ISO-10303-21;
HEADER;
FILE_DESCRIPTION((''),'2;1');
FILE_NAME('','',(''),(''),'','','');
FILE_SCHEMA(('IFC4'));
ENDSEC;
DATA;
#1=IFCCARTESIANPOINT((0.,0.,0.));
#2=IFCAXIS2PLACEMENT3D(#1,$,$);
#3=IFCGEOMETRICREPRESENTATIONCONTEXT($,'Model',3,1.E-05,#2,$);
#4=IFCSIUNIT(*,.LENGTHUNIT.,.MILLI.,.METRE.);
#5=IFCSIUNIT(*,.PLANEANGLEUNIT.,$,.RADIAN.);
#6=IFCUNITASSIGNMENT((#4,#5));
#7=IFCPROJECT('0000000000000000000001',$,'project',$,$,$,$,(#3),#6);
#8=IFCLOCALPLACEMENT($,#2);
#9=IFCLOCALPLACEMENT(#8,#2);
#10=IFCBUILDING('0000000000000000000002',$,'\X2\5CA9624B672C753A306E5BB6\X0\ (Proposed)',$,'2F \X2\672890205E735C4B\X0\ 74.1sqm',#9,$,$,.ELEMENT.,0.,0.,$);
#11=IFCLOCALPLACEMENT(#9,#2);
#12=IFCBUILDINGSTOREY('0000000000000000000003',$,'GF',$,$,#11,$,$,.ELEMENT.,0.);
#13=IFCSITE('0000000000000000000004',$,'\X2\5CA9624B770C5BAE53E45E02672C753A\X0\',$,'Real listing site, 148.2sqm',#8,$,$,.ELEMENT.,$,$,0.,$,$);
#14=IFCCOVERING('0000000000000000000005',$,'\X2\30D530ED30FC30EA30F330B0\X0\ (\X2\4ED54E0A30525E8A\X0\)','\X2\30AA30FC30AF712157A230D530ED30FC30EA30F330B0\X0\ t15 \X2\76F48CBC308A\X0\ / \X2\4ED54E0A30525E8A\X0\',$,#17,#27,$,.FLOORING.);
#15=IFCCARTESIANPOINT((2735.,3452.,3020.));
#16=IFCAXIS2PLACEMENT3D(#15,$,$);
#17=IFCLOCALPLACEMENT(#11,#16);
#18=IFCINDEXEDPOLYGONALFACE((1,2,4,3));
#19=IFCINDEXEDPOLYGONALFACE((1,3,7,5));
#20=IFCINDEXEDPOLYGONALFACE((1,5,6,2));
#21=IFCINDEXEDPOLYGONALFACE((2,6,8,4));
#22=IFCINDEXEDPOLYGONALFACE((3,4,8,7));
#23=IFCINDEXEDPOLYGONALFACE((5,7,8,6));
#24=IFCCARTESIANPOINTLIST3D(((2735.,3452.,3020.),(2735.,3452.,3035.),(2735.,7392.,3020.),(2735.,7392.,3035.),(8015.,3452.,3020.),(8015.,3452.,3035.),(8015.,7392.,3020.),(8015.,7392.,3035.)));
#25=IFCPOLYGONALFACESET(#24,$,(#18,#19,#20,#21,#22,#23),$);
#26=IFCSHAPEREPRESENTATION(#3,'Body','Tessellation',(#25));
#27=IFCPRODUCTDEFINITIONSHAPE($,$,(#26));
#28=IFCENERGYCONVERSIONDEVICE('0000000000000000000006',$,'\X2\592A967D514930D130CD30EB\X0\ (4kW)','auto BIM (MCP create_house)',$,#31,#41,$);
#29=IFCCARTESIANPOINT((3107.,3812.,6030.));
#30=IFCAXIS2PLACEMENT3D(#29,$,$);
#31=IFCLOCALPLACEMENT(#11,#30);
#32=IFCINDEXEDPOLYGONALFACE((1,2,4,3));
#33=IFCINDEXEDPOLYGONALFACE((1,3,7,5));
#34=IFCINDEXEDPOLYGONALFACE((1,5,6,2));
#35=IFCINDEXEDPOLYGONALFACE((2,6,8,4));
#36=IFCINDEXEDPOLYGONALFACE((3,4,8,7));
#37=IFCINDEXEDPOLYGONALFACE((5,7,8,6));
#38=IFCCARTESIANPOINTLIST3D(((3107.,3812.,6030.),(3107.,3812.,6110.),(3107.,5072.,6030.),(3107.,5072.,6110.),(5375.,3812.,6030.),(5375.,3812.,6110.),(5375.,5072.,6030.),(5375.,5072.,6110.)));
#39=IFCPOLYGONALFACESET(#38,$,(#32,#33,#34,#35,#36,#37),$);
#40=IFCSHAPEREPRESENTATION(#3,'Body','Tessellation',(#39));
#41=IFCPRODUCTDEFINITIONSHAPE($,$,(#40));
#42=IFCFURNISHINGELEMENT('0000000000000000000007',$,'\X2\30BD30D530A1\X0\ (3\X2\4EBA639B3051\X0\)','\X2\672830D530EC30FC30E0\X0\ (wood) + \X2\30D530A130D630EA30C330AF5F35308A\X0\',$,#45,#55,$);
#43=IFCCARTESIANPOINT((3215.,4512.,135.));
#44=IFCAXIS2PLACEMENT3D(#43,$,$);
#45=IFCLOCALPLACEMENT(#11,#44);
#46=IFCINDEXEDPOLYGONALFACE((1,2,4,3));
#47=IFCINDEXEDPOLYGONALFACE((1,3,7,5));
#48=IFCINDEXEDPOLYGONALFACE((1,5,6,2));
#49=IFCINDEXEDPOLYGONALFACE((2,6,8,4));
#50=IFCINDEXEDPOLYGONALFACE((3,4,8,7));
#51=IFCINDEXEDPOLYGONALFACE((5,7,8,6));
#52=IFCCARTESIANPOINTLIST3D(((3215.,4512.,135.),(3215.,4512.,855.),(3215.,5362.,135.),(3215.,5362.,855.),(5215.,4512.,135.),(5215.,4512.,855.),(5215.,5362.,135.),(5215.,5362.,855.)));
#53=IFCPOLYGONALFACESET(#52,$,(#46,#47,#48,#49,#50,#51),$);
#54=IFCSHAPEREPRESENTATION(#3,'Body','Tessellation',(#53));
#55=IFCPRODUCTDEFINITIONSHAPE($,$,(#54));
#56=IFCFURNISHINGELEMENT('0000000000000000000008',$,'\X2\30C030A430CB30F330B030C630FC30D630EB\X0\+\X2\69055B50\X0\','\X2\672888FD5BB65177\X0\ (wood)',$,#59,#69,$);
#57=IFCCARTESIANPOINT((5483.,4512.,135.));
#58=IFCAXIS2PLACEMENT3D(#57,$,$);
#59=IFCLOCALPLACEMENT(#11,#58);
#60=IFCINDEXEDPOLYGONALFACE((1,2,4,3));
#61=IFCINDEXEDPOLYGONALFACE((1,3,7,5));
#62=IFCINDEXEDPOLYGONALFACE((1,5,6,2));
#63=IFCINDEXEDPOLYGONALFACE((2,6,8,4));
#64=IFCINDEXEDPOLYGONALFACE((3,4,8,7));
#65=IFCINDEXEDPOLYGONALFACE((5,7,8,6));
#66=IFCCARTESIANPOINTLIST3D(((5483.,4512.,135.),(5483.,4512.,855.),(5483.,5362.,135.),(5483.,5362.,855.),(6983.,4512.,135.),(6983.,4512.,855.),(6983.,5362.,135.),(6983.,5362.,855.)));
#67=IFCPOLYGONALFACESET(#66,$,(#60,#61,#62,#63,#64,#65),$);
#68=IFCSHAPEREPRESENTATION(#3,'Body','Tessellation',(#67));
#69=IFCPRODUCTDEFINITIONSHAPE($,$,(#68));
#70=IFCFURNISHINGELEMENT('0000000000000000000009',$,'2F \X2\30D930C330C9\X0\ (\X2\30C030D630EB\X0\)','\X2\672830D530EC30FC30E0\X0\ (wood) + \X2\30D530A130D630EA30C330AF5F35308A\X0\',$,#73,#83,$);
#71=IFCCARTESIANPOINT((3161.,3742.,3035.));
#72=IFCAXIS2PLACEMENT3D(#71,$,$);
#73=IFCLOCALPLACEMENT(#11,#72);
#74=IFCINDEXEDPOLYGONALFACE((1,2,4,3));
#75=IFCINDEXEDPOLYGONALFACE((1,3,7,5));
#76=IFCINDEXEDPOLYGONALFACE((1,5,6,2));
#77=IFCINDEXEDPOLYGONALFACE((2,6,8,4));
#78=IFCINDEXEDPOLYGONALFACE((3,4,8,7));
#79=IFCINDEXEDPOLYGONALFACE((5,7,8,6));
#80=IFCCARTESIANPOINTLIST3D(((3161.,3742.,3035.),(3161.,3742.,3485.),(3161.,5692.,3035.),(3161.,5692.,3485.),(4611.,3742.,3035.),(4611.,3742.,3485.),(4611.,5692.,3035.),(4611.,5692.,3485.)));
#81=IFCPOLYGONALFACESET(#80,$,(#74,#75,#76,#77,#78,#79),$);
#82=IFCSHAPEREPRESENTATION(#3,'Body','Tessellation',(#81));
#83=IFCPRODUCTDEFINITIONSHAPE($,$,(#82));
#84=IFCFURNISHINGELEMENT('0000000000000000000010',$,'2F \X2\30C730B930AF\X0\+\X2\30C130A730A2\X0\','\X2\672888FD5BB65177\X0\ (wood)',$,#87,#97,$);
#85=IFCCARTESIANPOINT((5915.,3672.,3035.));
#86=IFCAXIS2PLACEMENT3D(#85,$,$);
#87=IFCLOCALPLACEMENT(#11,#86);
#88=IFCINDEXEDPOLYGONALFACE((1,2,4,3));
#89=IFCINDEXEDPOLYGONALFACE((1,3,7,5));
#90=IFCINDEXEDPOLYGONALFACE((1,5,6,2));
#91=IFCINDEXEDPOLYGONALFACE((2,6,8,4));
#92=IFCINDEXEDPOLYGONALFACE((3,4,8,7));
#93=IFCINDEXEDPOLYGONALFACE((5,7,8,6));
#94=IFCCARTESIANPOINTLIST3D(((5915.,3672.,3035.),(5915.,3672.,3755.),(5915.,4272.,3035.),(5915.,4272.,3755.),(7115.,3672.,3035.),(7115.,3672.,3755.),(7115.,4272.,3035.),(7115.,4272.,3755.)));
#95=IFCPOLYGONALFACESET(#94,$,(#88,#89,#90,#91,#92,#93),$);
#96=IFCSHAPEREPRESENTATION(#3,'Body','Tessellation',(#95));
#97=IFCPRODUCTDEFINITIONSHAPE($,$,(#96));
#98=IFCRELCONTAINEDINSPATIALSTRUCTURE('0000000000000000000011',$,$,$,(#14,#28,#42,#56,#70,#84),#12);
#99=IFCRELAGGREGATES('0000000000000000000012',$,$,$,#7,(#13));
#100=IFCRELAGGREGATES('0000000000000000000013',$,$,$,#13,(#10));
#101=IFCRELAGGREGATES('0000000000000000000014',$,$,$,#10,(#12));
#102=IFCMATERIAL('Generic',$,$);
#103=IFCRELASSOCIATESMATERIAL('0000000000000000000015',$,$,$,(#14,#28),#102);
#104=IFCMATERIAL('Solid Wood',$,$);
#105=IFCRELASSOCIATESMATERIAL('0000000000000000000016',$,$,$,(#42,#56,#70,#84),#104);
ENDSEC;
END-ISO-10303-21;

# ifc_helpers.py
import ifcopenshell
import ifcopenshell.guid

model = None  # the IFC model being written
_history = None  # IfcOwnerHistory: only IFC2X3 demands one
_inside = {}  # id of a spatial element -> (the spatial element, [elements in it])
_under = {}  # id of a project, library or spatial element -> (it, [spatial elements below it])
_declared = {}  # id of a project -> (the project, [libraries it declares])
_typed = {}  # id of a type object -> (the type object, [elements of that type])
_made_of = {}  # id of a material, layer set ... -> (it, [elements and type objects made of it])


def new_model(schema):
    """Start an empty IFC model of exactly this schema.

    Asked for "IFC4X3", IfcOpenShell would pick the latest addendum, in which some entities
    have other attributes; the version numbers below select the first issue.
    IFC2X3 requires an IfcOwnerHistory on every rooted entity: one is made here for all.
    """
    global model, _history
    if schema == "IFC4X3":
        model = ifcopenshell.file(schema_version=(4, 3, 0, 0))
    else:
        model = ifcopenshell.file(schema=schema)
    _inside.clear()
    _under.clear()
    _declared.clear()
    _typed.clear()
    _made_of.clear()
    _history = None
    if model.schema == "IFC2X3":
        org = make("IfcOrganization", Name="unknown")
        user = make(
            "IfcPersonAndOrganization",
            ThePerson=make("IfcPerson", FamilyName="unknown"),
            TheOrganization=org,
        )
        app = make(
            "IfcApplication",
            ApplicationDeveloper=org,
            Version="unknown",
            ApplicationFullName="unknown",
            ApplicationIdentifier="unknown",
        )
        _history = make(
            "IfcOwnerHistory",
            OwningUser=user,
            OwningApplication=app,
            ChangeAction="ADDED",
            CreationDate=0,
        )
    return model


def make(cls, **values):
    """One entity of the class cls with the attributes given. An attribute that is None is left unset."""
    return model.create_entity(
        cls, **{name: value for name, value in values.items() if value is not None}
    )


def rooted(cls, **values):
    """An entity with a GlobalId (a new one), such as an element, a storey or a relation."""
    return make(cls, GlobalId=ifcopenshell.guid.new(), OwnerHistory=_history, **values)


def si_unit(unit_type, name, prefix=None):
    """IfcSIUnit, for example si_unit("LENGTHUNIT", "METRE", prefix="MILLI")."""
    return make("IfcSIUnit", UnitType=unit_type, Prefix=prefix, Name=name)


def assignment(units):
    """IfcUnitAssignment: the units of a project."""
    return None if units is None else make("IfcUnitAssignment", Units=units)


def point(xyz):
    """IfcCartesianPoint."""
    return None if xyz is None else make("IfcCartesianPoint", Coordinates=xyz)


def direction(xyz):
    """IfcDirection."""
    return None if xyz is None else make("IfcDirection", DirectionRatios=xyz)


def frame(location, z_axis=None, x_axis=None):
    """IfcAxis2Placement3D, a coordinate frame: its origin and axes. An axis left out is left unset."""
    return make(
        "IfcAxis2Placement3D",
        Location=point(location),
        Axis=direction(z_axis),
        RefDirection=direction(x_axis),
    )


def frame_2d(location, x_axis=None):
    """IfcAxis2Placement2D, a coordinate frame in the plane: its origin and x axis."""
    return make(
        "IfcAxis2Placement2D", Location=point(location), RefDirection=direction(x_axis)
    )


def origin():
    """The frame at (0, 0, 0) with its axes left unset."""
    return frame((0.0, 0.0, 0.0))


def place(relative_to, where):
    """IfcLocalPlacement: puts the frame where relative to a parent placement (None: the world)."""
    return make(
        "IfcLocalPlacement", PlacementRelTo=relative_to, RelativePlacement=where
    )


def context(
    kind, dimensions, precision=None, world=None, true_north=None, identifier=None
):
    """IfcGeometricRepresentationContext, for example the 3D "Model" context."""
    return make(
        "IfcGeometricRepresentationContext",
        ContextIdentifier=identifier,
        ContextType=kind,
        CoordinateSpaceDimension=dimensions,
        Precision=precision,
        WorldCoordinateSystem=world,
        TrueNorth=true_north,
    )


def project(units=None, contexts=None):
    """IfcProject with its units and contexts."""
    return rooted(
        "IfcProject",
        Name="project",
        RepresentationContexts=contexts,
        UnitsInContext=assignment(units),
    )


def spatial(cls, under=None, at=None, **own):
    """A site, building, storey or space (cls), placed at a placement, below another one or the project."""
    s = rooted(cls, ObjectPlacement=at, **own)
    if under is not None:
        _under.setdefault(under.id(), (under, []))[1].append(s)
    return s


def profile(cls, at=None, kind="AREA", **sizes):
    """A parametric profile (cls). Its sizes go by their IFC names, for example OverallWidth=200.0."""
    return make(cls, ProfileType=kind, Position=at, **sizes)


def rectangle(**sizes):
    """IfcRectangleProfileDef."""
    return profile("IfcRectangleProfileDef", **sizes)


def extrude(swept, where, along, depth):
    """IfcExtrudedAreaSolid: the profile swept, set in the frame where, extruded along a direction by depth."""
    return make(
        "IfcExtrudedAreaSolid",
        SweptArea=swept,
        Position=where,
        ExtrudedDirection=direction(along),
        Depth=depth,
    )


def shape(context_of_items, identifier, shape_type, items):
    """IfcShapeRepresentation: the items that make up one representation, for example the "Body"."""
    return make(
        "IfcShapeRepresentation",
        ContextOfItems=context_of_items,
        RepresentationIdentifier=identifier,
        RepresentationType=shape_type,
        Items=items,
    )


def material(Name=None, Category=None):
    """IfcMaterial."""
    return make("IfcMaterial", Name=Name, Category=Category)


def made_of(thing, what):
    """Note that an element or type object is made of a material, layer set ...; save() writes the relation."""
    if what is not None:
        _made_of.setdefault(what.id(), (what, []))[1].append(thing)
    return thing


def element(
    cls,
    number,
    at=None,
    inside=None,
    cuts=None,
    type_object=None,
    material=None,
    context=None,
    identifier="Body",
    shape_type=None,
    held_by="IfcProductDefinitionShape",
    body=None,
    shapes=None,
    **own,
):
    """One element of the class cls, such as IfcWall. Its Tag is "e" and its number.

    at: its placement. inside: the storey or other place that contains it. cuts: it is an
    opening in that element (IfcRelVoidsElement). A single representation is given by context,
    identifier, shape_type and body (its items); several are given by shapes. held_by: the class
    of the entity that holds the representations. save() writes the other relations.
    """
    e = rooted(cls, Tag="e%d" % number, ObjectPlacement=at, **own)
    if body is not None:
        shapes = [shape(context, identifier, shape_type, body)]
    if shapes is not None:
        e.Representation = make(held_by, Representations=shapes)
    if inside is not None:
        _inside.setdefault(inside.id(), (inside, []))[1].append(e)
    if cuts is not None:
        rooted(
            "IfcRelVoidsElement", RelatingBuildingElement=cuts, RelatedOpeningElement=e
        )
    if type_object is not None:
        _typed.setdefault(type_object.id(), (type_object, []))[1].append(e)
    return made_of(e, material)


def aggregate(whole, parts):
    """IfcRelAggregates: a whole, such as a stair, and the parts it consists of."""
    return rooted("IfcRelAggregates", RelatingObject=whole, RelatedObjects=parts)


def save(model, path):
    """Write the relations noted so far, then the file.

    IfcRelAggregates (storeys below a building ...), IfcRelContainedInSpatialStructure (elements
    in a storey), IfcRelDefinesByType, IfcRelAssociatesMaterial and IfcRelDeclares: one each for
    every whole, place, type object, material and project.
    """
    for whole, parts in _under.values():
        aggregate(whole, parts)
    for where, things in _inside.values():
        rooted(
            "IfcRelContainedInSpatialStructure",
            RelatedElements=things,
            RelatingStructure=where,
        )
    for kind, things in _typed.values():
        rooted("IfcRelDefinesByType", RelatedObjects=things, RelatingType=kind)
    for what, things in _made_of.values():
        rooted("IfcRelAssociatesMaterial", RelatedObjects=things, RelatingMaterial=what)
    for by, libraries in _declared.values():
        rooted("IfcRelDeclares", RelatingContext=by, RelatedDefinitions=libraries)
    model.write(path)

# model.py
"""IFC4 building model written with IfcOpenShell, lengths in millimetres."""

from ifc_helpers import new_model, si_unit, frame, frame_2d, origin, place, context, project, spatial, rectangle, extrude, material, element, save


model = new_model("IFC4")

# Units and contexts
model_context = context("Model", 3, precision=1e-05, world=origin())
ifc_project = project(units=[si_unit("LENGTHUNIT", "METRE", prefix="MILLI"), si_unit("PLANEANGLEUNIT", "RADIAN")], contexts=[model_context])

# Site, building, storey
site_placement = place(None, origin())
site = spatial("IfcSite", under=ifc_project, at=site_placement, Name="岩手県宮古市本町", ObjectType="Real listing site, 148.2sqm", CompositionType="ELEMENT", RefElevation=0.0)
building_placement = place(site_placement, origin())
building = spatial("IfcBuilding", under=site, at=building_placement, Name="岩手本町の家 (Proposed)", ObjectType="2F 木造平屋 74.1sqm", CompositionType="ELEMENT", ElevationOfRefHeight=0.0, ElevationOfTerrain=0.0)
storey_placement = place(building_placement, origin())
storey = spatial("IfcBuildingStorey", under=building, at=storey_placement, Name="GF", CompositionType="ELEMENT", Elevation=0.0)

# Shared definitions
ifc_material_1 = material(Name="Solid Wood")

# Covering
ifc_material_2 = material(Name="Generic")
covering_placement = place(storey_placement, frame((2735.0, 3452.0, 3020.0)))
element("IfcCovering", 1, at=covering_placement, inside=storey, material=ifc_material_2, Name="フローリング (仕上げ床)", Description="オーク無垢フローリング t15 直貼り / 仕上げ床", PredefinedType="FLOORING", context=model_context, shape_type="SweptSolid", body=[
    extrude(rectangle(XDim=5280.0, YDim=3940.0, at=frame_2d((2640.0, 1970.0))), frame((2735.0, 3452.0, 3020.0)), (0.0, 0.0, 1.0), 15.0),
])

# Energy conversion device
energy_conversion_device_placement = place(storey_placement, frame((3107.0, 3812.0, 6030.0)))
element("IfcEnergyConversionDevice", 2, at=energy_conversion_device_placement, inside=storey, material=ifc_material_2, Name="太陽光パネル (4kW)", Description="auto BIM (MCP create_house)", context=model_context, shape_type="SweptSolid", body=[
    extrude(rectangle(XDim=2268.0, YDim=1260.0, at=frame_2d((1134.0, 630.0))), frame((3107.0, 3812.0, 6030.0)), (0.0, 0.0, 1.0), 80.0),
])

# Furnishing elements
furnishing_1_placement = place(storey_placement, frame((3215.0, 4512.0, 135.0)))
element("IfcFurnishingElement", 3, at=furnishing_1_placement, inside=storey, material=ifc_material_1, Name="ソファ (3人掛け)", Description="木フレーム (wood) + ファブリック張り", context=model_context, shape_type="SweptSolid", body=[
    extrude(rectangle(XDim=2000.0, YDim=850.0, at=frame_2d((1000.0, 425.0))), frame((3215.0, 4512.0, 135.0)), (0.0, 0.0, 1.0), 720.0),
])
furnishing_2_placement = place(storey_placement, frame((5483.0, 4512.0, 135.0)))
element("IfcFurnishingElement", 4, at=furnishing_2_placement, inside=storey, material=ifc_material_1, Name="ダイニングテーブル+椅子", Description="木製家具 (wood)", context=model_context, shape_type="SweptSolid", body=[
    extrude(rectangle(XDim=1500.0, YDim=850.0, at=frame_2d((750.0, 425.0))), frame((5483.0, 4512.0, 135.0)), (0.0, 0.0, 1.0), 720.0),
])
furnishing_3_placement = place(storey_placement, frame((3161.0, 3742.0, 3035.0)))
element("IfcFurnishingElement", 5, at=furnishing_3_placement, inside=storey, material=ifc_material_1, Name="2F ベッド (ダブル)", Description="木フレーム (wood) + ファブリック張り", context=model_context, shape_type="SweptSolid", body=[
    extrude(rectangle(XDim=1450.0, YDim=1950.0, at=frame_2d((725.0, 975.0))), frame((3161.0, 3742.0, 3035.0)), (0.0, 0.0, 1.0), 450.0),
])
furnishing_4_placement = place(storey_placement, frame((5915.0, 3672.0, 3035.0)))
element("IfcFurnishingElement", 6, at=furnishing_4_placement, inside=storey, material=ifc_material_1, Name="2F デスク+チェア", Description="木製家具 (wood)", context=model_context, shape_type="SweptSolid", body=[
    extrude(rectangle(XDim=1200.0, YDim=600.0, at=frame_2d((600.0, 300.0))), frame((5915.0, 3672.0, 3035.0)), (0.0, 0.0, 1.0), 720.0),
])

save(model, "model.ifc")
